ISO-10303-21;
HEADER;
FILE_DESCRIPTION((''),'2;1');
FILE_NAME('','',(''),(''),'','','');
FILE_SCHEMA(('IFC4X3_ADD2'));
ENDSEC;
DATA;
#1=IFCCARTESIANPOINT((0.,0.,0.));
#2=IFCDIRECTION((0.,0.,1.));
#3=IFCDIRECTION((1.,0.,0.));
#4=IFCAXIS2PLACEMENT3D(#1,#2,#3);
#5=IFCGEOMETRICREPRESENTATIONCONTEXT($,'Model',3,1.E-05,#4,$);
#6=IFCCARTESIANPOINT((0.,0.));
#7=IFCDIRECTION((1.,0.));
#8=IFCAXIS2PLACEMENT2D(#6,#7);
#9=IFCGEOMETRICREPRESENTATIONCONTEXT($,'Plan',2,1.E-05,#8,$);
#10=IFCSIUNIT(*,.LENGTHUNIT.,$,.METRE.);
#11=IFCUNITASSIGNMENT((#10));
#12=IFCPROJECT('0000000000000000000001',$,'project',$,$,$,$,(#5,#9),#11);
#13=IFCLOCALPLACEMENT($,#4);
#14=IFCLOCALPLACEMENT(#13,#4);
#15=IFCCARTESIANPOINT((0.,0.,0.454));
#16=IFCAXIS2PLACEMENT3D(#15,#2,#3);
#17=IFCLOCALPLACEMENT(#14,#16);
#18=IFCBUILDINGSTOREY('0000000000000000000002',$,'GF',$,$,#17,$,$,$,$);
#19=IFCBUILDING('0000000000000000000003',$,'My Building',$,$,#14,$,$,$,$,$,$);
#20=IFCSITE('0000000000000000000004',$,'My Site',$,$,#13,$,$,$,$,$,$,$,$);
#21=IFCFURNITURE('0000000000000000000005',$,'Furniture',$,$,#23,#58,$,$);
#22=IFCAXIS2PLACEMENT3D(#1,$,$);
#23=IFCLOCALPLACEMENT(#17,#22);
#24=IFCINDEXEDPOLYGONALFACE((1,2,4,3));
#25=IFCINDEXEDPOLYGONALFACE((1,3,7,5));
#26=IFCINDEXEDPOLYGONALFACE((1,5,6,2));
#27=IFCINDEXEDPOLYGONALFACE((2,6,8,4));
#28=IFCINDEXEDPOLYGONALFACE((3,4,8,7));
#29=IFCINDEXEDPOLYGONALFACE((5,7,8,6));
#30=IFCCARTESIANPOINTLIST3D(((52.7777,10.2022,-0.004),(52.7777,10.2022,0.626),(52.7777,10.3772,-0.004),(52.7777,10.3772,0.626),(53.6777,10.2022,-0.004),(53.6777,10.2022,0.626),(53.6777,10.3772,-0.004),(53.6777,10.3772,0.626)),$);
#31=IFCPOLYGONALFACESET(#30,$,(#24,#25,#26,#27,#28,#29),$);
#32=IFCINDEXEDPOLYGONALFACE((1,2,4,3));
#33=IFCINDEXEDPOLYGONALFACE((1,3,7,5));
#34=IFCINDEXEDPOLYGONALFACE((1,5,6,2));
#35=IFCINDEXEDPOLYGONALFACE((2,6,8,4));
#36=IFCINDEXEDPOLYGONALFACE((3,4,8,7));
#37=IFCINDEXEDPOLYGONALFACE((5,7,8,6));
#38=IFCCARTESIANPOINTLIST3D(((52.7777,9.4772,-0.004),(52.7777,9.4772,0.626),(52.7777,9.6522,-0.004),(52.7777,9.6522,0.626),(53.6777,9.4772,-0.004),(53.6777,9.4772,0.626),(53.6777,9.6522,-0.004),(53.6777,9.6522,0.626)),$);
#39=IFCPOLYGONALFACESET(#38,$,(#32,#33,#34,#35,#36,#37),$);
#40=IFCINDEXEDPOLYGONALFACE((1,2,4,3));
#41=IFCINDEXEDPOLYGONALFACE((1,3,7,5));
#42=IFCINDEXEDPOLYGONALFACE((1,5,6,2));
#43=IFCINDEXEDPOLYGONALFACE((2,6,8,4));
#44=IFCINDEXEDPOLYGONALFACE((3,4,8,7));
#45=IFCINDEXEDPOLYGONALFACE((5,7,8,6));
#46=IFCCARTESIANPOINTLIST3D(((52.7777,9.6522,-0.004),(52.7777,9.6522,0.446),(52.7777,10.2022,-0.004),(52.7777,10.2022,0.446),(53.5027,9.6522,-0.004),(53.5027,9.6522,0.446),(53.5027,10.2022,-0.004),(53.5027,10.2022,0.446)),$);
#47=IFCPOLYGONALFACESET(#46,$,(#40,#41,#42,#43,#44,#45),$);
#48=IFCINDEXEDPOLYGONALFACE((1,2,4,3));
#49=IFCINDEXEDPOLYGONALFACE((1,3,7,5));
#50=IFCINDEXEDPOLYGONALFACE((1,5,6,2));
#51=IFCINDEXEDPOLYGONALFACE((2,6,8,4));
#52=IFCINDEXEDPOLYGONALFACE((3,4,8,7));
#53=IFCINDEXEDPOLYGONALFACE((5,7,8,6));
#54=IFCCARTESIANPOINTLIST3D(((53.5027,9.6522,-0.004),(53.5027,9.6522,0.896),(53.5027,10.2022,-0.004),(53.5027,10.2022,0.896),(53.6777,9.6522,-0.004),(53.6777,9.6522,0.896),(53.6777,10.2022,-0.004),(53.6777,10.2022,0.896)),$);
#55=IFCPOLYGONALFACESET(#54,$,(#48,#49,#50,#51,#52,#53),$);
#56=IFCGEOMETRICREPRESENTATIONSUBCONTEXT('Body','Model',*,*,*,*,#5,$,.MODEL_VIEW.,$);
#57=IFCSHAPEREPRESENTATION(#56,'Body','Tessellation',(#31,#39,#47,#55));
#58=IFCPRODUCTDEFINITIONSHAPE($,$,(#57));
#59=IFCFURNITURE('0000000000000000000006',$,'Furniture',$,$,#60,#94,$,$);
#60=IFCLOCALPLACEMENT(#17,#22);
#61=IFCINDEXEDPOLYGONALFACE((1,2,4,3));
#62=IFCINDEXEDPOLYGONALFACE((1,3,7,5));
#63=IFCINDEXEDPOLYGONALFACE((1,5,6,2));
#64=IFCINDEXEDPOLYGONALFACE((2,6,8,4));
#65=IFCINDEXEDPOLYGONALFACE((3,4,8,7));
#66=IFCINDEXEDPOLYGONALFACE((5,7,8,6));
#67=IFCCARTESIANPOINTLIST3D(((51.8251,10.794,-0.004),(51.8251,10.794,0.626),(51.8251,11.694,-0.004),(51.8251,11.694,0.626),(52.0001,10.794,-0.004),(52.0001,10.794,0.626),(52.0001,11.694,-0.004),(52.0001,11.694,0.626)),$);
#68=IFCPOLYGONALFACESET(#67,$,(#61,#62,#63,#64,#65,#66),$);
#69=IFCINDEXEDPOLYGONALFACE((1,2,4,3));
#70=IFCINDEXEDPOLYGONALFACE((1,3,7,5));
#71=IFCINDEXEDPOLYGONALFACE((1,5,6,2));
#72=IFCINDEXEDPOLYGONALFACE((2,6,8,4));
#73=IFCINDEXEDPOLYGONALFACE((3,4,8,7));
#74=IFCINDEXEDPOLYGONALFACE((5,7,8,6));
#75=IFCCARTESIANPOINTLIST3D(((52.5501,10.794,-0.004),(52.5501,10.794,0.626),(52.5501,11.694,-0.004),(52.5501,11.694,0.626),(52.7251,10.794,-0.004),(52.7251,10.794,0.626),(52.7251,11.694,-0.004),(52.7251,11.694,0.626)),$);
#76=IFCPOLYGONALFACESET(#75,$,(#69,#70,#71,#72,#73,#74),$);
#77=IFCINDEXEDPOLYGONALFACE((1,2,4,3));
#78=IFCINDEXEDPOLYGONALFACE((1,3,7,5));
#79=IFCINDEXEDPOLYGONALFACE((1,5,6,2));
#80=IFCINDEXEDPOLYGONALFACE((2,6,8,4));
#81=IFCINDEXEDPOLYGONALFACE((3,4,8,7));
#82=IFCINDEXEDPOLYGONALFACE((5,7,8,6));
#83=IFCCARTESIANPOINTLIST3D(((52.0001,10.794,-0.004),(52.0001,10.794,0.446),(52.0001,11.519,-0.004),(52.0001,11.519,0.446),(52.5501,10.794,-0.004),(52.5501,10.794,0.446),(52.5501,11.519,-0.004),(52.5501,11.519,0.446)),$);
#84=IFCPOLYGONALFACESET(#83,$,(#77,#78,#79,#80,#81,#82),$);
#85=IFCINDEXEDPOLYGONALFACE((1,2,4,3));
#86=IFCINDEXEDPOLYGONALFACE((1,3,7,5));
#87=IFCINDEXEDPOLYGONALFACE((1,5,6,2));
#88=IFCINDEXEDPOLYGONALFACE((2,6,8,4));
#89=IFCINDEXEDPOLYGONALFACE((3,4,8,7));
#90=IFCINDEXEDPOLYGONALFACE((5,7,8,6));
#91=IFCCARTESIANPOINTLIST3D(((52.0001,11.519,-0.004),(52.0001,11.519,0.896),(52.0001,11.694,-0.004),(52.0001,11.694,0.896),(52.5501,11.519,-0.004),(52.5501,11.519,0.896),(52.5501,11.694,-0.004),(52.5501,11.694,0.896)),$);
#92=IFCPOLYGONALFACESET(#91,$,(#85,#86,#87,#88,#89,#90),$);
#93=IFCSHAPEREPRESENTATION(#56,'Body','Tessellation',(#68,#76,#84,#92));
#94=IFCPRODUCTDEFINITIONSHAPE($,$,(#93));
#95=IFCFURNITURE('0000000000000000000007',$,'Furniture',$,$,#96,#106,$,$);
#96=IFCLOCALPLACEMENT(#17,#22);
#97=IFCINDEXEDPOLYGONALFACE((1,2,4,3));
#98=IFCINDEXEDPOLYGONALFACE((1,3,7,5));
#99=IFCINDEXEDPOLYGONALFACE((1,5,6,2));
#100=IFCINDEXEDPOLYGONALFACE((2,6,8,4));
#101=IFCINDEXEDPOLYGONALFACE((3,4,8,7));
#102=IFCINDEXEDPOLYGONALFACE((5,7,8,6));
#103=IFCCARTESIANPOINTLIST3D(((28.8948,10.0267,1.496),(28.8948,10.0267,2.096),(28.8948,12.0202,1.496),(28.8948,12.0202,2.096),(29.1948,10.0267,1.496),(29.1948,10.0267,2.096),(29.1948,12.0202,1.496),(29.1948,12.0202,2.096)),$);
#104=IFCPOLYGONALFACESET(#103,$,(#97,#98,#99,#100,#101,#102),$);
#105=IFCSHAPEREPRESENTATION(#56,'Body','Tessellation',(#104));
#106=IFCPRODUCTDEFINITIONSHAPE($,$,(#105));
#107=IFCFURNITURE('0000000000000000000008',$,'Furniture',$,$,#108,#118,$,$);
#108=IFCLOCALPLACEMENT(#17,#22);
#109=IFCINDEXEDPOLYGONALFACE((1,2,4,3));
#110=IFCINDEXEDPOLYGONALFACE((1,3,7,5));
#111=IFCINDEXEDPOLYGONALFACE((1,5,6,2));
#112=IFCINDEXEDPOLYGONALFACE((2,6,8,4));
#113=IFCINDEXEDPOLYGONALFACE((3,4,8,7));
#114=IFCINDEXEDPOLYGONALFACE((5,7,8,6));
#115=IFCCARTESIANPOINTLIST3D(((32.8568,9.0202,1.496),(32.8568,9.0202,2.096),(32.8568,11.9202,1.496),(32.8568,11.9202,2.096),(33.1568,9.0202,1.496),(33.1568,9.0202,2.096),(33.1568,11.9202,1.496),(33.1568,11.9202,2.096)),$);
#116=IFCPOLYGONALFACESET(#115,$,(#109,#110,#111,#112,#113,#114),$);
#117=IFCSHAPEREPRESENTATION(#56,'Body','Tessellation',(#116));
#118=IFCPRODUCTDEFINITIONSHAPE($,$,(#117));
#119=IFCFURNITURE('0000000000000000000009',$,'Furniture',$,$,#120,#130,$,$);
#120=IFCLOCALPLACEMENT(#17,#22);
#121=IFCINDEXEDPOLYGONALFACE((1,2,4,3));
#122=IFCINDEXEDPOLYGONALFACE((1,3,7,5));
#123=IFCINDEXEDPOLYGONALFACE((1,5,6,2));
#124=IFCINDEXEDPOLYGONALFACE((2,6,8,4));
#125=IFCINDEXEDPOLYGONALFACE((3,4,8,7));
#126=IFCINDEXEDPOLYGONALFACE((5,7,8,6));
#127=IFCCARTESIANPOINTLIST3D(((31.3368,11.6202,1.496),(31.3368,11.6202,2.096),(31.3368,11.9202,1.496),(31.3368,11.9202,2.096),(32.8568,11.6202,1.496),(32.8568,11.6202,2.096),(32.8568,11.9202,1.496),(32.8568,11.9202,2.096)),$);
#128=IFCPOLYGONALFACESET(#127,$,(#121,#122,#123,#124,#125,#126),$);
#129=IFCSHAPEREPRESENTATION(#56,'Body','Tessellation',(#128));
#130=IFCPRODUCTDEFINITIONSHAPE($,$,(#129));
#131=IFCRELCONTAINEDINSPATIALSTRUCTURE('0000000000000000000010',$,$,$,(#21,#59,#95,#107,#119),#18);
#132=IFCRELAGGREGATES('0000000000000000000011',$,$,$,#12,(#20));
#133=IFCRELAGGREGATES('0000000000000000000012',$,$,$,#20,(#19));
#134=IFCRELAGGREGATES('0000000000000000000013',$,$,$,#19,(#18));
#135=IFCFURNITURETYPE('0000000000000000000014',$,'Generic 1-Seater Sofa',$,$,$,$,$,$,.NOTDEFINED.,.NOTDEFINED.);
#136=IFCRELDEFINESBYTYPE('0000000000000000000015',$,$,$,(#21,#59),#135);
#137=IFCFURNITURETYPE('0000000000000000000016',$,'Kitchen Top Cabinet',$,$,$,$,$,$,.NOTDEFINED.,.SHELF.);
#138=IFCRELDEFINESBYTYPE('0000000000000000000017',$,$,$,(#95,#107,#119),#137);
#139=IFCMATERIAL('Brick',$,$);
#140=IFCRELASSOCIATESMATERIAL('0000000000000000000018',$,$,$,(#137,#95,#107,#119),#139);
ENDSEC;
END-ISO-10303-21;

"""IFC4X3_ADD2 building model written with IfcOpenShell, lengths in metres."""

from ifc_helpers import new_model, entity, si_unit, frame, origin_with_axes, origin_2d_with_axis, place, context, subcontext, project, spatial, line, indexed_curve, rectangle, outline, extrude, shape, source, transform, mapped, material, material_profile, profile_set, profile_usage, type_object, type_shapes, element, save


model = new_model("IFC4X3_ADD2")

# Units and contexts
model_context = context("Model", 3, precision=1e-05, world=origin_with_axes())
plan_context = context("Plan", 2, precision=1e-05, world=origin_2d_with_axis())
body_context_1 = subcontext(model_context, "Body", "Model", "MODEL_VIEW")
body_context_2 = subcontext(plan_context, "Body", "Plan", "PLAN_VIEW")
ifc_project = project(units=[si_unit("LENGTHUNIT", "METRE")], contexts=[model_context, plan_context])

# Site, building, storey
site_placement = place(None, origin_with_axes())
site = spatial("IfcSite", under=ifc_project, at=site_placement, Name="My Site")
building_placement = place(site_placement, origin_with_axes())
building = spatial("IfcBuilding", under=site, at=building_placement, Name="My Building")
storey_placement = place(building_placement, frame((0.0, 0.0, 0.454), z_axis=(0.0, 0.0, 1.0), x_axis=(1.0, 0.0, 0.0)))
storey = spatial("IfcBuildingStorey", under=building, at=storey_placement, Name="GF")

# Shared definitions
ifc_material_1 = material(Name="Brick")

# Furniture
furniture_type_1 = type_object("IfcFurnitureType", Name="Generic 1-Seater Sofa", AssemblyPlace="NOTDEFINED", PredefinedType="NOTDEFINED")
shared_shape_1 = source(origin_with_axes(), body_context_1, "Body", "SweptSolid", [
    extrude(outline(indexed_curve([(0.0, 0.0), (0.175, 0.0), (0.175, 0.9), (0.0, 0.9)], segments=[line(4, 1), line(1, 2), line(2, 3), line(3, 4)], self_intersect=False)), frame((-0.45, -0.9, 0.0), z_axis=(0.0, 0.0, 1.0), x_axis=(1.0, 0.0, 0.0)), (0.0, 0.0, 1.0), 0.63),
    extrude(outline(indexed_curve([(0.0, 0.0), (0.175, 0.0), (0.175, 0.9), (0.0, 0.9)], segments=[line(1, 2, 3, 4, 1)])), frame((0.275, -0.9, 0.0), z_axis=(0.0, 0.0, 1.0), x_axis=(1.0, 0.0, 0.0)), (0.0, 0.0, 1.0), 0.63),
    extrude(outline(indexed_curve([(0.175, 0.0), (0.725, 0.0), (0.725, 0.725), (0.175, 0.725)], segments=[line(1, 2, 3, 4, 1)])), frame((-0.45, -0.9, 0.0), z_axis=(0.0, 0.0, 1.0), x_axis=(1.0, 0.0, 0.0)), (0.0, 0.0, 1.0), 0.45),
    extrude(outline(indexed_curve([(0.175, 0.725), (0.725, 0.725), (0.725, 0.9), (0.175, 0.9)], segments=[line(1, 2, 3, 4, 1)])), frame((-0.45, -0.9, 0.0), z_axis=(0.0, 0.0, 1.0), x_axis=(1.0, 0.0, 0.0)), (0.0, 0.0, 1.0), 0.9),
])
shared_shape_2 = source(origin_with_axes(), body_context_2, "Body", "Annotation2D", [
    entity("IfcGeometricCurveSet", [entity("IfcIndexedPolyCurve", entity("IfcCartesianPointList2D", [[0.275, -0.175], [0.275, -0.9], [0.45, -0.9], [0.45, 0.0], [0.275, 0.0], [0.275, -0.9], [-0.275, -0.9], [-0.275, 0.0], [-0.275, -0.175], [0.275, -0.175], [0.275, 0.0], [-0.275, 0.0], [-0.45, 0.0], [-0.45, -0.9], [-0.275, -0.9], [-0.275, -0.175]]))]),
])
type_shapes(furniture_type_1, [shared_shape_1, shared_shape_2])
for number, where, z_axis, x_axis, name in (
    (1, (53.6777, 9.9272, -0.004), (0.0, 0.0, 1.0), (0.0, -1.0, 0.0), "Furniture"),
    (2, (52.2751, 11.694, -0.004), (0.0, 0.0, 1.0), (1.0, 0.0, 0.0), "Furniture"),
):
    element("IfcFurniture", number, at=place(storey_placement, frame(where, z_axis=z_axis, x_axis=x_axis)), inside=storey, type_object=furniture_type_1, Name=name, shapes=[
        shape(body_context_1, "Body", "MappedRepresentation", [mapped(shared_shape_1, transform((0.0, 0.0, 0.0), x_axis=(1.0, 0.0, 0.0), y_axis=(0.0, 1.0, 0.0), z_axis=(0.0, 0.0, 1.0), scale=1.0))]),
        shape(body_context_2, "Body", "MappedRepresentation", [mapped(shared_shape_2, transform((0.0, 0.0, 0.0), x_axis=(1.0, 0.0, 0.0), y_axis=(0.0, 1.0, 0.0), z_axis=(0.0, 0.0, 1.0), scale=1.0))]),
    ])
ifc_material_profile_1 = material_profile(ifc_material_1, rectangle(XDim=0.3, YDim=0.6))
ifc_profile_set_1 = profile_set([ifc_material_profile_1], Name="blank")
ifc_profile_usage_1 = profile_usage(ifc_profile_set_1, cardinal=5)
furniture_type_2 = type_object("IfcFurnitureType", Name="Kitchen Top Cabinet", AssemblyPlace="NOTDEFINED", PredefinedType="SHELF", material=ifc_profile_set_1)
furniture_1_placement = place(storey_placement, frame((29.0448, 12.0202, 1.796), z_axis=(0.0, -1.0, 0.0), x_axis=(1.0, 0.0, 0.0)))
element("IfcFurniture", 3, at=furniture_1_placement, inside=storey, type_object=furniture_type_2, material=ifc_profile_usage_1, Name="Furniture", context=body_context_1, shape_type="SweptSolid", body=[
    extrude(rectangle(XDim=0.3, YDim=0.6), origin_with_axes(), (0.0, 0.0, 1.0), 1.9936),
])
ifc_profile_usage_2 = profile_usage(ifc_profile_set_1, cardinal=5)
furniture_2_placement = place(storey_placement, frame((33.0068, 11.9202, 1.796), z_axis=(0.0, -1.0, 0.0), x_axis=(1.0, 0.0, 0.0)))
element("IfcFurniture", 4, at=furniture_2_placement, inside=storey, type_object=furniture_type_2, material=ifc_profile_usage_2, Name="Furniture", context=body_context_1, shape_type="SweptSolid", body=[
    extrude(rectangle(XDim=0.3, YDim=0.6), origin_with_axes(), (0.0, 0.0, 1.0), 2.9),
])
ifc_profile_usage_3 = profile_usage(ifc_profile_set_1, cardinal=5)
furniture_3_placement = place(storey_placement, frame((32.8568, 11.7702, 1.796), z_axis=(-1.0, 0.0, 0.0), x_axis=(0.0, -1.0, 0.0)))
element("IfcFurniture", 5, at=furniture_3_placement, inside=storey, type_object=furniture_type_2, material=ifc_profile_usage_3, Name="Furniture", context=body_context_1, shape_type="SweptSolid", body=[
    extrude(rectangle(XDim=0.3, YDim=0.6), origin_with_axes(), (0.0, 0.0, 1.0), 1.52),
])

save(model, "model.ifc")
